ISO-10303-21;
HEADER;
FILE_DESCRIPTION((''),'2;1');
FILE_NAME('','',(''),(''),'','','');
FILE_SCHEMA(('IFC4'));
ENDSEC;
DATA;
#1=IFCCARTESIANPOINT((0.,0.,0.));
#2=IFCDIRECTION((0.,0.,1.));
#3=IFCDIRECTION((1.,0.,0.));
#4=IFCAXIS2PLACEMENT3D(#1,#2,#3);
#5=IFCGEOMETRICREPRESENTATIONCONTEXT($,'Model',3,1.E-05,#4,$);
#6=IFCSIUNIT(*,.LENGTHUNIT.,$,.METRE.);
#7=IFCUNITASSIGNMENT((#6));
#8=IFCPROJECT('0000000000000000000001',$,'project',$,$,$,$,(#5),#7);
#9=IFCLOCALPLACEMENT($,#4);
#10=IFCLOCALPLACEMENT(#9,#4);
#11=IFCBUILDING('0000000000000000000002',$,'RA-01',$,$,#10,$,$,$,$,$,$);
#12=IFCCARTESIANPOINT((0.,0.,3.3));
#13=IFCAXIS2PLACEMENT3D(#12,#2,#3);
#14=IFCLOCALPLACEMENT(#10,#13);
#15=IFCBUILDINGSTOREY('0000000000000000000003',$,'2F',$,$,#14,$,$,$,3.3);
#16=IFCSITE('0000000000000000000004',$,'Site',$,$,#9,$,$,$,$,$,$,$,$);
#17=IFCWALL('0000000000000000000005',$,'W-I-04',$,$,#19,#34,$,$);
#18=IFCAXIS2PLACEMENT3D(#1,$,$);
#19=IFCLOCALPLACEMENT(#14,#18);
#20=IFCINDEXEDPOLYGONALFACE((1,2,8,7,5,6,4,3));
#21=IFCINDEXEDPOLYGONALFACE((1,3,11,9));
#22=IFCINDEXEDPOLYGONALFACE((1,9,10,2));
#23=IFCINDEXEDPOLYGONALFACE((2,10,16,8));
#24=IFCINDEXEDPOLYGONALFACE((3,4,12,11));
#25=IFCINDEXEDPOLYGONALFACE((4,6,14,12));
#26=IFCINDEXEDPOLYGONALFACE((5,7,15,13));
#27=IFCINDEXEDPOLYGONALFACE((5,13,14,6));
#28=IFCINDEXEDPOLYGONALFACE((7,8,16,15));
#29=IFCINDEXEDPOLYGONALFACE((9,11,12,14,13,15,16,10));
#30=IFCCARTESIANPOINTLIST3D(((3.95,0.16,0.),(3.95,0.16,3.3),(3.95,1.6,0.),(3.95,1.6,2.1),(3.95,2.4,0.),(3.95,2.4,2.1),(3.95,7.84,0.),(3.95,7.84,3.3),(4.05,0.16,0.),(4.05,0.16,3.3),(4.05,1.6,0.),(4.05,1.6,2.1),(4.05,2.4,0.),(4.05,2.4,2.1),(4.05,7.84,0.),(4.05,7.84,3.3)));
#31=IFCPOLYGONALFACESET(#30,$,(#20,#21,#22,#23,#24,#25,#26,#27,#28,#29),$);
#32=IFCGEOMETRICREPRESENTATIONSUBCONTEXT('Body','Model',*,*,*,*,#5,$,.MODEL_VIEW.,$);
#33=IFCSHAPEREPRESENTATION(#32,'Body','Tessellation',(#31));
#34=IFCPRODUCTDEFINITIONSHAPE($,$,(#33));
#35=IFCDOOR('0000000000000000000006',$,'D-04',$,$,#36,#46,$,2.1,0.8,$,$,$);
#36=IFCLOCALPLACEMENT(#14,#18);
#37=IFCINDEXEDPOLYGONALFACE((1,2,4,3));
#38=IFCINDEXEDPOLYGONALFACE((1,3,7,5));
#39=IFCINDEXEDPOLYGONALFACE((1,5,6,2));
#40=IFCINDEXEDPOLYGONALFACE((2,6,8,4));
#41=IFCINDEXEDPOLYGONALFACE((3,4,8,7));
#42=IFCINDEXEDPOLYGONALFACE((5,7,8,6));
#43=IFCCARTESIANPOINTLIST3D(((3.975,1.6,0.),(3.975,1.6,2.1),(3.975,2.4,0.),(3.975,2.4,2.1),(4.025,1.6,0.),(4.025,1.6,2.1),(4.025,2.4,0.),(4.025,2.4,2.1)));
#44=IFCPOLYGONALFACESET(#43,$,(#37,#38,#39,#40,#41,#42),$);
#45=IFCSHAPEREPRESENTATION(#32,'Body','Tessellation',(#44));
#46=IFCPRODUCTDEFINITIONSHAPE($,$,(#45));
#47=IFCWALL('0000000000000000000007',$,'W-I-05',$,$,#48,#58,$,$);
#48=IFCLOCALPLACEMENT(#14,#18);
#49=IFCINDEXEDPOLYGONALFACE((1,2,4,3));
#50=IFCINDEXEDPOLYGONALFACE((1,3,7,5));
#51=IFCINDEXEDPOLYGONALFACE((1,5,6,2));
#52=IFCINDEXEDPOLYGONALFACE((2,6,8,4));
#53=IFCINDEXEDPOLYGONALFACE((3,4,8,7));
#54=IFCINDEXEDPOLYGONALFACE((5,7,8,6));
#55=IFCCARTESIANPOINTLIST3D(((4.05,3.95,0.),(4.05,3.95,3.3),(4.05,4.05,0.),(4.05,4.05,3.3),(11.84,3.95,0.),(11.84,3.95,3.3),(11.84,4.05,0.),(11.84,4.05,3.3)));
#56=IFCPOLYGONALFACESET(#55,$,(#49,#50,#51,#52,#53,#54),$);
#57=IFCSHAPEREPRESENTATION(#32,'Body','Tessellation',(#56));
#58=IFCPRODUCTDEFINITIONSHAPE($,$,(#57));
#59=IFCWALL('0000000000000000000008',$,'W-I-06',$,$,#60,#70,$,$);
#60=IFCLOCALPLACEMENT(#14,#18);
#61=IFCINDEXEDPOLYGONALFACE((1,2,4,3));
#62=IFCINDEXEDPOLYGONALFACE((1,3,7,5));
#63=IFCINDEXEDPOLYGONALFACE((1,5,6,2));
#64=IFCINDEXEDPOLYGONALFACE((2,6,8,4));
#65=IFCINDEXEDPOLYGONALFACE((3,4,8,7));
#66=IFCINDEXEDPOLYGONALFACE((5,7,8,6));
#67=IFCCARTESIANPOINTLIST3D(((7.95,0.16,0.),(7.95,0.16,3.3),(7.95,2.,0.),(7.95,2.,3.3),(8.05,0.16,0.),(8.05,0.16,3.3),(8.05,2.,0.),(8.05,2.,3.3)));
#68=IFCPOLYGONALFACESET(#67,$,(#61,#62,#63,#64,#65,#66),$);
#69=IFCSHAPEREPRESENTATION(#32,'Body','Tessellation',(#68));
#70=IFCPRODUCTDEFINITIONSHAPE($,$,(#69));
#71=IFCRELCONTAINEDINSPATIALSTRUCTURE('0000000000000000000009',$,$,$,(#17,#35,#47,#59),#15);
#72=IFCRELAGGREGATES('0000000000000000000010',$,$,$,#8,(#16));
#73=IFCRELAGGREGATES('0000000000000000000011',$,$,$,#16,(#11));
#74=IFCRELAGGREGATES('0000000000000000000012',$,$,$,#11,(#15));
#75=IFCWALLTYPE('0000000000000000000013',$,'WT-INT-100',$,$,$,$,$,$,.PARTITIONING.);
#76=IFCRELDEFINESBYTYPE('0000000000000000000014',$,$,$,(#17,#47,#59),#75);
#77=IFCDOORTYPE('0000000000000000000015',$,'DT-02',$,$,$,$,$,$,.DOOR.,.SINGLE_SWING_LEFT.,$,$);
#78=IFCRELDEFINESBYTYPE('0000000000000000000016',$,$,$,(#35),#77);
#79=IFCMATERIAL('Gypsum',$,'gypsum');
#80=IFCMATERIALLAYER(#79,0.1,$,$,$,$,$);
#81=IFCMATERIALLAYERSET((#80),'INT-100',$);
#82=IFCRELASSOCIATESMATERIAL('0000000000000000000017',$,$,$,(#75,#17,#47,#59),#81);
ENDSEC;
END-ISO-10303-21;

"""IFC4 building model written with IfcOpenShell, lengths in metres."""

from ifc_helpers import new_model, si_unit, frame, frame_2d, origin_with_axes, origin_2d_with_axis, place, context, subcontext, project, spatial, rectangle, extrude, material, layer, layer_set, layer_usage, type_object, element, fill, save


model = new_model("IFC4")

# Units and contexts
model_context = context("Model", 3, precision=1e-05, world=origin_with_axes())
body_context = subcontext(model_context, "Body", "Model", "MODEL_VIEW")
ifc_project = project(units=[si_unit("LENGTHUNIT", "METRE")], contexts=[model_context])

# Site, building, storey
site_placement = place(None, origin_with_axes())
site = spatial("IfcSite", under=ifc_project, at=site_placement, Name="Site")
building_placement = place(site_placement, origin_with_axes())
building = spatial("IfcBuilding", under=site, at=building_placement, Name="RA-01")
storey_placement = place(building_placement, frame((0.0, 0.0, 3.3), z_axis=(0.0, 0.0, 1.0), x_axis=(1.0, 0.0, 0.0)))
storey = spatial("IfcBuildingStorey", under=building, at=storey_placement, Name="2F", Elevation=3.3)

# Wall, opening, door
ifc_material_1 = material(Name="Gypsum", Category="gypsum")
ifc_layer_1 = layer(ifc_material_1, 0.1)
ifc_layer_set_1 = layer_set([ifc_layer_1], Name="INT-100")
ifc_layer_usage_1 = layer_usage(ifc_layer_set_1, "AXIS2", "POSITIVE", -0.05)
wall_type_1 = type_object("IfcWallType", Name="WT-INT-100", PredefinedType="PARTITIONING", material=ifc_layer_set_1)
wall_1_placement = place(storey_placement, frame((4.0, 0.16, 0.0), z_axis=(0.0, 0.0, 1.0), x_axis=(0.0, 1.0, 0.0)))
wall_1 = element("IfcWall", 1, at=wall_1_placement, inside=storey, type_object=wall_type_1, material=ifc_layer_usage_1, Name="W-I-04", context=body_context, shape_type="SweptSolid", body=[
    extrude(rectangle(XDim=7.68, YDim=0.1, at=frame_2d((3.84, 0.0), x_axis=(1.0, 0.0))), origin_with_axes(), (0.0, 0.0, 1.0), 3.3),
])
opening_1_placement = place(wall_1_placement, frame((1.84, 0.0, 0.0), z_axis=(0.0, 0.0, 1.0), x_axis=(1.0, 0.0, 0.0)))
opening_1 = element("IfcOpeningElement", 2, at=opening_1_placement, cuts=wall_1, PredefinedType="OPENING", context=body_context, shape_type="SweptSolid", body=[
    extrude(rectangle(XDim=0.8, YDim=0.2, at=origin_2d_with_axis()), origin_with_axes(), (0.0, 0.0, 1.0), 2.1),
])
door_type_1 = type_object("IfcDoorType", Name="DT-02", OperationType="SINGLE_SWING_LEFT", PredefinedType="DOOR")
door_1_placement = place(opening_1_placement, origin_with_axes())
door_1 = element("IfcDoor", 3, at=door_1_placement, inside=storey, type_object=door_type_1, Name="D-04", OverallHeight=2.1, OverallWidth=0.8, context=body_context, shape_type="SweptSolid", body=[
    extrude(rectangle(XDim=0.8, YDim=0.05, at=origin_2d_with_axis()), origin_with_axes(), (0.0, 0.0, 1.0), 2.1),
])
fill(opening_1, door_1)

# Walls
ifc_layer_usage_2 = layer_usage(ifc_layer_set_1, "AXIS2", "POSITIVE", -0.05)
wall_2_placement = place(storey_placement, frame((4.05, 4.0, 0.0), z_axis=(0.0, 0.0, 1.0), x_axis=(1.0, 0.0, 0.0)))
element("IfcWall", 4, at=wall_2_placement, inside=storey, type_object=wall_type_1, material=ifc_layer_usage_2, Name="W-I-05", context=body_context, shape_type="SweptSolid", body=[
    extrude(rectangle(XDim=7.79, YDim=0.1, at=frame_2d((3.895, 0.0), x_axis=(1.0, 0.0))), origin_with_axes(), (0.0, 0.0, 1.0), 3.3),
])
ifc_layer_usage_3 = layer_usage(ifc_layer_set_1, "AXIS2", "POSITIVE", -0.05)
wall_3_placement = place(storey_placement, frame((8.0, 0.16, 0.0), z_axis=(0.0, 0.0, 1.0), x_axis=(0.0, 1.0, 0.0)))
element("IfcWall", 5, at=wall_3_placement, inside=storey, type_object=wall_type_1, material=ifc_layer_usage_3, Name="W-I-06", context=body_context, shape_type="SweptSolid", body=[
    extrude(rectangle(XDim=1.84, YDim=0.1, at=frame_2d((0.92, 0.0), x_axis=(1.0, 0.0))), origin_with_axes(), (0.0, 0.0, 1.0), 3.3),
])

save(model, "model.ifc")
